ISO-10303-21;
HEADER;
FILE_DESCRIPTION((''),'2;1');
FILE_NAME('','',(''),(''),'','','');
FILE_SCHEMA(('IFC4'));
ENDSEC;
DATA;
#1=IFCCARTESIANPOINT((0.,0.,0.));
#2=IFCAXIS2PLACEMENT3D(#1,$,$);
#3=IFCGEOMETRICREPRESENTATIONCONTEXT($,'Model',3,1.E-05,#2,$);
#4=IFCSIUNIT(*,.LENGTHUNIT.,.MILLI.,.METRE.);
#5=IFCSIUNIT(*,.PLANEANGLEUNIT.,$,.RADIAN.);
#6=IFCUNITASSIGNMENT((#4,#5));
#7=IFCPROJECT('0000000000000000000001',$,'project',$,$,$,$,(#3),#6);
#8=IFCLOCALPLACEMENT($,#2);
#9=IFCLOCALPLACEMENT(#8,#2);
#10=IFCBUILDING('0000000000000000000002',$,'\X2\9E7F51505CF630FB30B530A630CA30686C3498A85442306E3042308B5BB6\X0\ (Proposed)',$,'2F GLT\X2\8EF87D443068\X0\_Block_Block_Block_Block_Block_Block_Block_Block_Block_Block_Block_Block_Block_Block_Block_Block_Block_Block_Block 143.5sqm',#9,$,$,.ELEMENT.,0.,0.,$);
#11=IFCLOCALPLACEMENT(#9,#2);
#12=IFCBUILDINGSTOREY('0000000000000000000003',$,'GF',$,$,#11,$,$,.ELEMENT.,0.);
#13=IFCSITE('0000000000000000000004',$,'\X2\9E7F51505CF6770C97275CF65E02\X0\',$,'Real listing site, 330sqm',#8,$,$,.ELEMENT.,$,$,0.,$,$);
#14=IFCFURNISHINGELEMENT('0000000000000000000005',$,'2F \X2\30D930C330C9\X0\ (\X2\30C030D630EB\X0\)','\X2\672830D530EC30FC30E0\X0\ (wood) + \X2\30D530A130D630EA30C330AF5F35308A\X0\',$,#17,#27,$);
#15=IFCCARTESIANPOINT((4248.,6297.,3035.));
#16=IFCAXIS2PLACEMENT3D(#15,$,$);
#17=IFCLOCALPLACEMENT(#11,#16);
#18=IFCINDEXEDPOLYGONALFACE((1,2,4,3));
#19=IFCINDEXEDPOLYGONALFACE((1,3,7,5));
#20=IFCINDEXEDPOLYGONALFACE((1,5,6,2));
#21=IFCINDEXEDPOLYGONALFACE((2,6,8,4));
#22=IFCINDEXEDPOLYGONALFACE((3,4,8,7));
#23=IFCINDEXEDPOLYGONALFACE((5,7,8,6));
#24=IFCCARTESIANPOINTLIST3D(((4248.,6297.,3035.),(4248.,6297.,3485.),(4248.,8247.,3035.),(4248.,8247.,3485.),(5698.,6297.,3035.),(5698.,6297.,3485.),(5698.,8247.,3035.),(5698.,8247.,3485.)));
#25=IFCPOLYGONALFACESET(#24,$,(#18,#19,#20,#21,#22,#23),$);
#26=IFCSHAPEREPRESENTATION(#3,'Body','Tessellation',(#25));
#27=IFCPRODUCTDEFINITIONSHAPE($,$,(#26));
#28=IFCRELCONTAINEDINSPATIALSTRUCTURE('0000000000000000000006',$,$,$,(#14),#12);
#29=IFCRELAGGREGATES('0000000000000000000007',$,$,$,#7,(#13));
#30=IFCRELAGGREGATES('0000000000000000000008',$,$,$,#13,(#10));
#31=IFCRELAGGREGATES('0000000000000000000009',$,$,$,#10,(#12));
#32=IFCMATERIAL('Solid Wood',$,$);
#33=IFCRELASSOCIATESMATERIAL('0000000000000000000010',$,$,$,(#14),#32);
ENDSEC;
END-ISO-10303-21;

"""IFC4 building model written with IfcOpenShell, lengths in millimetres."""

from ifc_helpers import new_model, si_unit, frame, frame_2d, origin, place, context, project, spatial, rectangle, extrude, material, element, save


model = new_model("IFC4")

# Units and contexts
model_context = context("Model", 3, precision=1e-05, world=origin())
ifc_project = project(units=[si_unit("LENGTHUNIT", "METRE", prefix="MILLI"), si_unit("PLANEANGLEUNIT", "RADIAN")], contexts=[model_context])

# Site, building, storey
site_placement = place(None, origin())
site = spatial("IfcSite", under=ifc_project, at=site_placement, Name="鹿児島県霧島市", ObjectType="Real listing site, 330sqm", CompositionType="ELEMENT", RefElevation=0.0)
building_placement = place(site_placement, origin())
building = spatial("IfcBuilding", under=site, at=building_placement, Name="鹿児島・サウナと水風呂のある家 (Proposed)", ObjectType="2F GLT軸組と_Block_Block_Block_Block_Block_Block_Block_Block_Block_Block_Block_Block_Block_Block_Block_Block_Block_Block_Block 143.5sqm", CompositionType="ELEMENT", ElevationOfRefHeight=0.0, ElevationOfTerrain=0.0)
storey_placement = place(building_placement, origin())
storey = spatial("IfcBuildingStorey", under=building, at=storey_placement, Name="GF", CompositionType="ELEMENT", Elevation=0.0)

# Shared definitions
ifc_material_1 = material(Name="Solid Wood")

# Furnishing element
furnishing_1_placement = place(storey_placement, frame((4248.0, 6297.0, 3035.0)))
element("IfcFurnishingElement", 1, at=furnishing_1_placement, inside=storey, material=ifc_material_1, Name="2F ベッド (ダブル)", Description="木フレーム (wood) + ファブリック張り", context=model_context, shape_type="SweptSolid", body=[
    extrude(rectangle(XDim=1450.0, YDim=1950.0, at=frame_2d((725.0, 975.0))), frame((4248.0, 6297.0, 3035.0)), (0.0, 0.0, 1.0), 450.0),
])

save(model, "model.ifc")
